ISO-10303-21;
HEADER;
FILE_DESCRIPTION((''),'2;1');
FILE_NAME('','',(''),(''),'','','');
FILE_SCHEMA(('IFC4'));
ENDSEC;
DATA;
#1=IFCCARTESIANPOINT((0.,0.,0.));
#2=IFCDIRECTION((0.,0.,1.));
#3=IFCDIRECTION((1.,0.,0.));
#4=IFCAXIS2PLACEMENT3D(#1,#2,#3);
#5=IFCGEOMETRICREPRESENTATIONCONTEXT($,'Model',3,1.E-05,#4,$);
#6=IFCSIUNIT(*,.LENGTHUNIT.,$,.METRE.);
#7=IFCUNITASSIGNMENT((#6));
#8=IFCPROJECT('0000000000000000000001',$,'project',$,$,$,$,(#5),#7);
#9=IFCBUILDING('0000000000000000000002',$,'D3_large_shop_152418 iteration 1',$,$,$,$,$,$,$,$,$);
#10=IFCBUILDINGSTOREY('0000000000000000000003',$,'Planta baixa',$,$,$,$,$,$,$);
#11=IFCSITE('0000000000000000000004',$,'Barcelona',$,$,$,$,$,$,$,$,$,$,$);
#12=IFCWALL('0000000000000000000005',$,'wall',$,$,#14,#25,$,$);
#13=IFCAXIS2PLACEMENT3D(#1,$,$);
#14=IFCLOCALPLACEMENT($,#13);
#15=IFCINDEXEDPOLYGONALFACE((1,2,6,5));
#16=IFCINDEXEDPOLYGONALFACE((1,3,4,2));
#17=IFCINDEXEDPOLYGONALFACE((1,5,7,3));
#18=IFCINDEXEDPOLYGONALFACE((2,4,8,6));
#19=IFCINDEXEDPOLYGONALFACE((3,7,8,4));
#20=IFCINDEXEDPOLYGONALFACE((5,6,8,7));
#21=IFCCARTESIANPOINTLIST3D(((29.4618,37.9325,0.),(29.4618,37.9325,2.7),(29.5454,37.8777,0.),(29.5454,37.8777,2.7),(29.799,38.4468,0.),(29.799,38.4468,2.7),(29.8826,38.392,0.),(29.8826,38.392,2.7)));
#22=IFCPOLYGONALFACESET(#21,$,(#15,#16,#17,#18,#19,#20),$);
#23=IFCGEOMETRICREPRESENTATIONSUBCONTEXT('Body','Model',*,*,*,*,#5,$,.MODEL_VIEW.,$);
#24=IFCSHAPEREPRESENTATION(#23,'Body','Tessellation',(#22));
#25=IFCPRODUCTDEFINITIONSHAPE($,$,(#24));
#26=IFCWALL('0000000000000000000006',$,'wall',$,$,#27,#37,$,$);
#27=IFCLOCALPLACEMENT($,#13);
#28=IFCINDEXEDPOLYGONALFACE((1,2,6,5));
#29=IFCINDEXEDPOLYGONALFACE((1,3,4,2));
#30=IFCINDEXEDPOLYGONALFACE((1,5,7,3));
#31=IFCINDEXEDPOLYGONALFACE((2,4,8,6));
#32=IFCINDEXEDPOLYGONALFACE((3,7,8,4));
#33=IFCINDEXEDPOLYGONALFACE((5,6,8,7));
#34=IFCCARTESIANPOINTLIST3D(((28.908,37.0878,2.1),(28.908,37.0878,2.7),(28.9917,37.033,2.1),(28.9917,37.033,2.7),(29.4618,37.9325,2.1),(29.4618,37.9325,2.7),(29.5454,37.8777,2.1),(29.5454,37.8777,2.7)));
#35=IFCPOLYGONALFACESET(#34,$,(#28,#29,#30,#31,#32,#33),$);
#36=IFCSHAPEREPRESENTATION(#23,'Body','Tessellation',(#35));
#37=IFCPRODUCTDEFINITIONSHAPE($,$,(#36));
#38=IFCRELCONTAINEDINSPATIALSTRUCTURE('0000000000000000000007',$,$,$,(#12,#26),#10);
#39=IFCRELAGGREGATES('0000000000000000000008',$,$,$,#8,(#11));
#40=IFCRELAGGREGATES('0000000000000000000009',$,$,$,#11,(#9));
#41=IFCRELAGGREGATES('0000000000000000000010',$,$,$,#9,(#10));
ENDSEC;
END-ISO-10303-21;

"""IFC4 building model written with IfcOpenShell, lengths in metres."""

from ifc_helpers import new_model, si_unit, frame, origin, origin_with_axes, place, context, subcontext, project, spatial, polyline, outline, extrude, element, save


model = new_model("IFC4")

# Units and contexts
model_context = context("Model", 3, precision=1e-05, world=origin_with_axes())
body_context = subcontext(model_context, "Body", "Model", "MODEL_VIEW")
ifc_project = project(units=[si_unit("LENGTHUNIT", "METRE")], contexts=[model_context])

# Site, building, storey
site = spatial("IfcSite", under=ifc_project, Name="Barcelona")
building = spatial("IfcBuilding", under=site, Name="D3_large_shop_152418 iteration 1")
storey = spatial("IfcBuildingStorey", under=building, Name="Planta baixa")

# Walls
wall_1_placement = place(None, origin_with_axes())
element("IfcWall", 1, at=wall_1_placement, inside=storey, Name="wall", context=body_context, shape_type="SweptSolid", body=[
    extrude(outline(polyline([(29.8826, 38.392), (29.5454, 37.8777), (29.4618, 37.9325), (29.799, 38.4468), (29.8826, 38.392)])), origin(), (0.0, 0.0, 1.0), 2.7),
])
wall_2_placement = place(None, origin_with_axes())
element("IfcWall", 2, at=wall_2_placement, inside=storey, Name="wall", context=body_context, shape_type="SweptSolid", body=[
    extrude(outline(polyline([(29.5454, 37.8777), (28.9917, 37.033), (28.908, 37.0878), (29.4618, 37.9325), (29.5454, 37.8777)])), frame((0.0, 0.0, 2.1)), (0.0, 0.0, 1.0), 0.6),
])

save(model, "model.ifc")
